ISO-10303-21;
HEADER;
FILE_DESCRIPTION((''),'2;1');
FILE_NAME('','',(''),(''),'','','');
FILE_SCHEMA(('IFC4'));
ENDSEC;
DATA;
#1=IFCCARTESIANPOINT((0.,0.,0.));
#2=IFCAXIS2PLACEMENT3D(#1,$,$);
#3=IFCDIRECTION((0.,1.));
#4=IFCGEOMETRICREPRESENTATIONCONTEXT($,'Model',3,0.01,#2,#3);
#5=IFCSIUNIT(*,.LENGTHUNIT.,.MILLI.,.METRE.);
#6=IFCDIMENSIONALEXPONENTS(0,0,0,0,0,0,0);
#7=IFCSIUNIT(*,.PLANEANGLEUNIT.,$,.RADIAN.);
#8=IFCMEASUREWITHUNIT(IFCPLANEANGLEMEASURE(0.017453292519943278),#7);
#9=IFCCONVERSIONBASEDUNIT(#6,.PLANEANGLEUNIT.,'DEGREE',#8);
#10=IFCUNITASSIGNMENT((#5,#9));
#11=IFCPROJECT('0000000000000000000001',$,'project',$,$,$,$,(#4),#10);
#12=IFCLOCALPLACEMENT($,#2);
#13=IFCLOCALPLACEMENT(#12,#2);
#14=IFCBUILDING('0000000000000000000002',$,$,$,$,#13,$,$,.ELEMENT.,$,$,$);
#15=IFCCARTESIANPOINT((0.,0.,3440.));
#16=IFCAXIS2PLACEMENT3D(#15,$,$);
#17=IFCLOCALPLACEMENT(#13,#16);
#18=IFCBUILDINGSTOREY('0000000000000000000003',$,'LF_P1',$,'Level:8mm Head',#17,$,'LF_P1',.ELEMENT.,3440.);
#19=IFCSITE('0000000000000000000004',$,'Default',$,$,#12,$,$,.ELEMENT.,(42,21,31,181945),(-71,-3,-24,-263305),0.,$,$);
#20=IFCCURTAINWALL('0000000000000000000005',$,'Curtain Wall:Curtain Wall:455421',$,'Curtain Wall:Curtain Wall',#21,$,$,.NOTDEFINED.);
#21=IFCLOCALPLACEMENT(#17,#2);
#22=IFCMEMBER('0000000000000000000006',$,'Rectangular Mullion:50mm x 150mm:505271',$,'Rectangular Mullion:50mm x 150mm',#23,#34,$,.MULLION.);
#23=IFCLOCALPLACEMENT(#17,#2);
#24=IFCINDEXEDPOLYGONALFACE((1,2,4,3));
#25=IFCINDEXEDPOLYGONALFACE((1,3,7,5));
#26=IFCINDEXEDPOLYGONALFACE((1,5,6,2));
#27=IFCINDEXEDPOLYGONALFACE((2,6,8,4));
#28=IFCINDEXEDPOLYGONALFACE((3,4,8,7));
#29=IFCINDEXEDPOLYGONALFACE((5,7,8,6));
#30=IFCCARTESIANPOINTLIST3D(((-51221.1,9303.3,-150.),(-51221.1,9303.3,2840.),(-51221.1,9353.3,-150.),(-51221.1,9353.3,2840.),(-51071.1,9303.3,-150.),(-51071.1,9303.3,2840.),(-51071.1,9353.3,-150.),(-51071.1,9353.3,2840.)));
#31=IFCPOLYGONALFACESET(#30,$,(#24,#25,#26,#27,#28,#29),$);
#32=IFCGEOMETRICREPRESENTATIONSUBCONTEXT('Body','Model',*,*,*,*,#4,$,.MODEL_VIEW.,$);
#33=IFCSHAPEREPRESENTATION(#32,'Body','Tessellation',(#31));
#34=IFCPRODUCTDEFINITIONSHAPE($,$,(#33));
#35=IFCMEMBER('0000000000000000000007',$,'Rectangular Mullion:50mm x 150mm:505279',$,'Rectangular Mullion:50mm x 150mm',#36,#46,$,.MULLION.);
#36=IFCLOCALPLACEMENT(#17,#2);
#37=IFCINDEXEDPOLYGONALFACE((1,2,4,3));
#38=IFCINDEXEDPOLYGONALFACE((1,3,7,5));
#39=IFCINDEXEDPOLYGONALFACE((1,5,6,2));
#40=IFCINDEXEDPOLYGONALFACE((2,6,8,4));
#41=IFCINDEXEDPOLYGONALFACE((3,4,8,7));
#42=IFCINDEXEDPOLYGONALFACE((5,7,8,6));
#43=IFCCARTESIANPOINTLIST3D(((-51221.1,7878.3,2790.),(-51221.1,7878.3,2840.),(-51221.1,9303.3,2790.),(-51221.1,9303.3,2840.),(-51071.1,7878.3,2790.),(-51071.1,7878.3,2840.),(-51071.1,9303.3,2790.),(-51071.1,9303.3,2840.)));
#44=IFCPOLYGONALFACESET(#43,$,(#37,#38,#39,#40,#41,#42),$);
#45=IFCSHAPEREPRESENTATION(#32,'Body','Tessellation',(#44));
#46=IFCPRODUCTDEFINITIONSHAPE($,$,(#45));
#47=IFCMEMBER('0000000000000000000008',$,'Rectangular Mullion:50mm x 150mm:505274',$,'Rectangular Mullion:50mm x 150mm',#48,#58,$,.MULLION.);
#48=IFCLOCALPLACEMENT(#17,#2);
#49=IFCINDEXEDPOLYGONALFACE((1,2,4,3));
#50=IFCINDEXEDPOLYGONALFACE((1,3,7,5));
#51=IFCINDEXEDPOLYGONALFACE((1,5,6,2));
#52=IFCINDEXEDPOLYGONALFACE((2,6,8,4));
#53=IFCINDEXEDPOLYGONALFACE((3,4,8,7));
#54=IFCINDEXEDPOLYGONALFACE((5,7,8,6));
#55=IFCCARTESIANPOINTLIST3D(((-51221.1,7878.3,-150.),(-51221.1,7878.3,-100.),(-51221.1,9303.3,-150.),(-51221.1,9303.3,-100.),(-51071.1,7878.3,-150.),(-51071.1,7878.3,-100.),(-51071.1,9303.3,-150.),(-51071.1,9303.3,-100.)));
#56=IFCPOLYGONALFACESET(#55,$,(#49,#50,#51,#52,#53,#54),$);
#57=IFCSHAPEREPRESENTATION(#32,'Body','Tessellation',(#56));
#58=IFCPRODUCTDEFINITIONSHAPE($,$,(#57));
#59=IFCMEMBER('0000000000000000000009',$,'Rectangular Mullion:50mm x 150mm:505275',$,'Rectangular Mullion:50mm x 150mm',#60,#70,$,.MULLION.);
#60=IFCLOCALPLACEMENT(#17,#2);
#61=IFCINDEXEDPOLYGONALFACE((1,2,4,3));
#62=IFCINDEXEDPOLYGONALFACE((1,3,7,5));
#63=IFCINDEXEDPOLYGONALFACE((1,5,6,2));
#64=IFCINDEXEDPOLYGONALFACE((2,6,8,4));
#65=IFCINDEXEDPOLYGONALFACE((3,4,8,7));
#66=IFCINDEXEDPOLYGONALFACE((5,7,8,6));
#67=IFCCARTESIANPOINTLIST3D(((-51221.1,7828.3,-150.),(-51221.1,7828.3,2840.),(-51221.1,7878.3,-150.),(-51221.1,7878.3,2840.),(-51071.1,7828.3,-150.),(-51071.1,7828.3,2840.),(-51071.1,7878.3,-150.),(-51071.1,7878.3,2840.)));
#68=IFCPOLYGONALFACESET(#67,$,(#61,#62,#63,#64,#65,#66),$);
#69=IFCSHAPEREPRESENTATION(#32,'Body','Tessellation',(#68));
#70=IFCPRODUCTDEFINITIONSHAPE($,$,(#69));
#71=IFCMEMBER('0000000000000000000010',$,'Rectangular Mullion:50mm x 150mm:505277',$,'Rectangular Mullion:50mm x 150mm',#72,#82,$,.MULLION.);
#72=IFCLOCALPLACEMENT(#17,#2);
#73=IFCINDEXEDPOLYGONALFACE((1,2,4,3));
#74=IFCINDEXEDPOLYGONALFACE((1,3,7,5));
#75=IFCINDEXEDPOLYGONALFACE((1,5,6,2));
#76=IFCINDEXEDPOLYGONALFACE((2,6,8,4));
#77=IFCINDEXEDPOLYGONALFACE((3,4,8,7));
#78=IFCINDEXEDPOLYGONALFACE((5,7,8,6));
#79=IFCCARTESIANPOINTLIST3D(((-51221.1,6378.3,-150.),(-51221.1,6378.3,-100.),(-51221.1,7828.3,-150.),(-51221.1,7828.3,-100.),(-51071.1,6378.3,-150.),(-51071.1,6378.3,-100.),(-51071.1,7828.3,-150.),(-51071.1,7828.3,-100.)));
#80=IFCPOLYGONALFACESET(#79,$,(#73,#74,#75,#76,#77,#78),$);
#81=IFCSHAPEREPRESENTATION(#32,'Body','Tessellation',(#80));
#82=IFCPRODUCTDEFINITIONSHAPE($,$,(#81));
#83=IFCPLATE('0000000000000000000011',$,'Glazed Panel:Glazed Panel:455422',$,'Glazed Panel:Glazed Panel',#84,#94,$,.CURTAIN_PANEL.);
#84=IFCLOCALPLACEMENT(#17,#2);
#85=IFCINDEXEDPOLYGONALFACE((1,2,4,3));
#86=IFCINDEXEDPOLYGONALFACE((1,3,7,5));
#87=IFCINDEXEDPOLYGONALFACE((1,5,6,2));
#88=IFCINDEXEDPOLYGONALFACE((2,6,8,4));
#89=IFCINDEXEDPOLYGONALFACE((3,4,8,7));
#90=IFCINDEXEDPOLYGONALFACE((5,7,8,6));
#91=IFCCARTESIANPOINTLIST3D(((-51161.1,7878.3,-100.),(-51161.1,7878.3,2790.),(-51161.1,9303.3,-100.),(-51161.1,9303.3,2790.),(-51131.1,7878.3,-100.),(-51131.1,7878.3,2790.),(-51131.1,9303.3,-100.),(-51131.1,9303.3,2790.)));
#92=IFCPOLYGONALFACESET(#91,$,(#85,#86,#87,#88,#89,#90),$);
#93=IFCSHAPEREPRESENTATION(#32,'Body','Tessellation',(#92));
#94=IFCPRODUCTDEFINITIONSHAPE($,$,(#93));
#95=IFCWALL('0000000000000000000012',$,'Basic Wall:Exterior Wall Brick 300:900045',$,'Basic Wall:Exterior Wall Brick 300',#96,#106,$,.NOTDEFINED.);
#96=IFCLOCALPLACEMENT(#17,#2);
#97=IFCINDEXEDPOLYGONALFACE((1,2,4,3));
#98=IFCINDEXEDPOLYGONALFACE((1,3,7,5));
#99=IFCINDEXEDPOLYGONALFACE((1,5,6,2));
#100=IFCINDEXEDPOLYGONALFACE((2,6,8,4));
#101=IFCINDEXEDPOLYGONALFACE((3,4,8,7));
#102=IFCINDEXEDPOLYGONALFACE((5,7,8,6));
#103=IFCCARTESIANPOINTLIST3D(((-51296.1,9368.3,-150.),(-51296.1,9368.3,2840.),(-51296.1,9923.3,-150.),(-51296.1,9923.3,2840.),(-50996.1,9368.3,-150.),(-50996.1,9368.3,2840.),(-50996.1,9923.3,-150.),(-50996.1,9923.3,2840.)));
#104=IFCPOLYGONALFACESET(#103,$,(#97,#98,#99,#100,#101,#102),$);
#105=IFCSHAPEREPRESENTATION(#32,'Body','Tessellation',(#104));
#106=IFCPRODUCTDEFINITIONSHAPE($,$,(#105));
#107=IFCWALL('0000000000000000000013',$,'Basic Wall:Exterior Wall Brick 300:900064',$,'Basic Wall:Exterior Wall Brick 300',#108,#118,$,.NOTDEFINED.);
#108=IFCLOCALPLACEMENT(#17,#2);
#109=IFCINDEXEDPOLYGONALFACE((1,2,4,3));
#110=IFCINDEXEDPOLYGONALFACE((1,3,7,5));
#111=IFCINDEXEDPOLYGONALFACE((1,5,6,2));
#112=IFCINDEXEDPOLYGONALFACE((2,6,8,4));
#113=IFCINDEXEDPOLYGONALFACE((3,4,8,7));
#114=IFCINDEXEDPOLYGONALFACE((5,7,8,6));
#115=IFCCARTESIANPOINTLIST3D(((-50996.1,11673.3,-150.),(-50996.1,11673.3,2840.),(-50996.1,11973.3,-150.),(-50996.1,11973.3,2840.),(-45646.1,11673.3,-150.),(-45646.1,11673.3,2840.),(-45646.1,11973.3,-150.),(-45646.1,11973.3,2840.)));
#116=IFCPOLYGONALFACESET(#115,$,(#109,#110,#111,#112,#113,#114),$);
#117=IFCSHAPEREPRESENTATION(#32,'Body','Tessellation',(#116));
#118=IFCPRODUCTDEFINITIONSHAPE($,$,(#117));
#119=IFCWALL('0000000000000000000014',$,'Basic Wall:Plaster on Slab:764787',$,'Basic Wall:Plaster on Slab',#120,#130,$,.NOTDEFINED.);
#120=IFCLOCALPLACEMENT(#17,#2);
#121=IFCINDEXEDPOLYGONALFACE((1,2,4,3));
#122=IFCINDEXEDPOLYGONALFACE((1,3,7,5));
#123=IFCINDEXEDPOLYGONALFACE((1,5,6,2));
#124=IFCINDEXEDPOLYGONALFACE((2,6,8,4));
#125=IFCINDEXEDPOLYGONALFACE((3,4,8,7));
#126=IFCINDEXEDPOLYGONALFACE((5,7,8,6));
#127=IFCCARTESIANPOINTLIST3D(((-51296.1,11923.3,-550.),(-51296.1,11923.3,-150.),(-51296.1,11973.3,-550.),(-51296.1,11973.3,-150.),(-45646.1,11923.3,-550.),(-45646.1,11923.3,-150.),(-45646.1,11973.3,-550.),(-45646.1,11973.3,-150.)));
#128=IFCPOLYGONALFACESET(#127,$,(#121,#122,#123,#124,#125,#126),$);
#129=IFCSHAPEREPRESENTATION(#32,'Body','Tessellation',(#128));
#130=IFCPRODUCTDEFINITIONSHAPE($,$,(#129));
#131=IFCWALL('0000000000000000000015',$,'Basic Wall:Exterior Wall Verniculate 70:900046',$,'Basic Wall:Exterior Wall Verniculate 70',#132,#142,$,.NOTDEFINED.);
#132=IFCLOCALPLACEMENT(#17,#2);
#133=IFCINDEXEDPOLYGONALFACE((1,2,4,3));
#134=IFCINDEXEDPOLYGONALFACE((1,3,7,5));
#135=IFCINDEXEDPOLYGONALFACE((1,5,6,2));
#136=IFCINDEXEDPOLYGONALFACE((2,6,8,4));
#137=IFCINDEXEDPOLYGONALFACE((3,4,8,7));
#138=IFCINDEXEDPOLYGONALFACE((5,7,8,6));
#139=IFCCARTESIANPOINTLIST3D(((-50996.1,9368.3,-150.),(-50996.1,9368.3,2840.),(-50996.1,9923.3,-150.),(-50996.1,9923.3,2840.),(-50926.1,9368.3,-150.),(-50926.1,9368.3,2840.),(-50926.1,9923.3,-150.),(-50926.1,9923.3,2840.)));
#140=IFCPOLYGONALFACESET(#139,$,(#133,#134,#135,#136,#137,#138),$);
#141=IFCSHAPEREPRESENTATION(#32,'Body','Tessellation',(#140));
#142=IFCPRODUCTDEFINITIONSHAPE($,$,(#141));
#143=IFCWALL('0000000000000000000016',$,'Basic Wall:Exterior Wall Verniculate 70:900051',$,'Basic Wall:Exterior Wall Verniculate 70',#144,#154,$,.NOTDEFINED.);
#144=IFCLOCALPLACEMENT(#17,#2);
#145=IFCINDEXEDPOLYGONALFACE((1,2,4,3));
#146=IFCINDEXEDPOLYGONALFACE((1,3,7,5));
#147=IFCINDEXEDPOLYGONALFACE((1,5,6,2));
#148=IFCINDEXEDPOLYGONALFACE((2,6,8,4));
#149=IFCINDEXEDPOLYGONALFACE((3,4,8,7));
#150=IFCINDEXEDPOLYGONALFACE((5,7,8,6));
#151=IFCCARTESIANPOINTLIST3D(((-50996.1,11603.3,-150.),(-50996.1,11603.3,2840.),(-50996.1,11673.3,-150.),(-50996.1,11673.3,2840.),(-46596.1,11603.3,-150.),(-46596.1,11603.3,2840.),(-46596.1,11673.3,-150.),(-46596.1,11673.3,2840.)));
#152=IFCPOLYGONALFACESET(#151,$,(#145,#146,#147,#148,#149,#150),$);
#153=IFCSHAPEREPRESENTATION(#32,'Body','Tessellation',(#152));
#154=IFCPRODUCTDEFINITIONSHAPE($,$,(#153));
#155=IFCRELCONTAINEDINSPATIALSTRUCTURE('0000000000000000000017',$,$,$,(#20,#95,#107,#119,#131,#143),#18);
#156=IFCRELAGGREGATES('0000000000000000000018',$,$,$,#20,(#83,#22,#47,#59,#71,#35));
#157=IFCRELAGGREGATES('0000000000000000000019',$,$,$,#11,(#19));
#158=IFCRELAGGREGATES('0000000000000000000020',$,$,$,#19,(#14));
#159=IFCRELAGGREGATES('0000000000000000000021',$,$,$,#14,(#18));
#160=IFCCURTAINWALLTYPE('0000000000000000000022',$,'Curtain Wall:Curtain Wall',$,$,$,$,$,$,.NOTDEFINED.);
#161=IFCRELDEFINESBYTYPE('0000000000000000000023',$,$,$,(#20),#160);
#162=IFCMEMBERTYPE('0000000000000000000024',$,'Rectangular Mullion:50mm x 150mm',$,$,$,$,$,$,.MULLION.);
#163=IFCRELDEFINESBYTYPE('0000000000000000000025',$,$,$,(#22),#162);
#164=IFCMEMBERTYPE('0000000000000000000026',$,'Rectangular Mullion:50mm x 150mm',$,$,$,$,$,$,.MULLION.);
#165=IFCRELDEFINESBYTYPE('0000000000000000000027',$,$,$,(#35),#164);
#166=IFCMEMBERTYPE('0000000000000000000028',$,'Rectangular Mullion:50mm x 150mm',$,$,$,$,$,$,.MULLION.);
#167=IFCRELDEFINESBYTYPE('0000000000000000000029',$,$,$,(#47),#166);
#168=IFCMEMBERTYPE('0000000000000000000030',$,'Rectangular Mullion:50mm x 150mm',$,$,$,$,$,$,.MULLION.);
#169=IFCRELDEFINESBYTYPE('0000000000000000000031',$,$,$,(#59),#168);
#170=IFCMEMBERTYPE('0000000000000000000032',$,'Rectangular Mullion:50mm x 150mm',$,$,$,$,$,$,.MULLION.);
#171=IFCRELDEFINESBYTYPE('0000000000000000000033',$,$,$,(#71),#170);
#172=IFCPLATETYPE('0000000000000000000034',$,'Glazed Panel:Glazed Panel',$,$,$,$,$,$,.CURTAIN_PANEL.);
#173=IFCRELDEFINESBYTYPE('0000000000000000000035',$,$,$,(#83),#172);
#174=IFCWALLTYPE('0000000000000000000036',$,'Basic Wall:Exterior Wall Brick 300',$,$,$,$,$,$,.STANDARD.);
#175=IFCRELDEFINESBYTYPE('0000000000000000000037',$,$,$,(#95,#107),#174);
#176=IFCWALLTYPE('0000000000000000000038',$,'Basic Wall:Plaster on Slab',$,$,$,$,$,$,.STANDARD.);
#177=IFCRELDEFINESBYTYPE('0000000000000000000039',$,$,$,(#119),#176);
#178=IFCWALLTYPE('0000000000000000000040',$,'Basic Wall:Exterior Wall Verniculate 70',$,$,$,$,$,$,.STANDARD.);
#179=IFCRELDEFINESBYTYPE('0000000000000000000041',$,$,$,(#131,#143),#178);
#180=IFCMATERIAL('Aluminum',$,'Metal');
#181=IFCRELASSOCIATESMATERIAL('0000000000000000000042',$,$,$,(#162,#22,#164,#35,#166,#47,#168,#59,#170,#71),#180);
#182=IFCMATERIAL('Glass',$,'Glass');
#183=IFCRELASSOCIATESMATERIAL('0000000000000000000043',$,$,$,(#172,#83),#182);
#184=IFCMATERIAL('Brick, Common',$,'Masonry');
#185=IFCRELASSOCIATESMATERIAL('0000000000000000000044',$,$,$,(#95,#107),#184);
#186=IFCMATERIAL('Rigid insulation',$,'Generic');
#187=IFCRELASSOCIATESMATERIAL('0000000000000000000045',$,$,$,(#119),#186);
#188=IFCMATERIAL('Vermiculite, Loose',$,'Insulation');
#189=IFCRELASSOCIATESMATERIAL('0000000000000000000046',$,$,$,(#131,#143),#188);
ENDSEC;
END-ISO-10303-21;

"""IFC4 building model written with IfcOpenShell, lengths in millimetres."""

from ifc_helpers import new_model, entity, si_unit, converted_unit, direction, frame, origin, place, context, subcontext, project, spatial, indexed_curve, outline, extrude, source, transform, mapped, material, type_object, type_shapes, element, aggregate, save


model = new_model("IFC4")

# Units and contexts
model_context = context("Model", 3, precision=0.01, world=origin(), true_north=direction((0.0, 1.0)))
body_context = subcontext(model_context, "Body", "Model", "MODEL_VIEW")
ifc_project = project(units=[si_unit("LENGTHUNIT", "METRE", prefix="MILLI"), converted_unit("PLANEANGLEUNIT", "DEGREE", entity("IfcPlaneAngleMeasure", 0.017453292519943278), si_unit("PLANEANGLEUNIT", "RADIAN"), dimensions=[0, 0, 0, 0, 0, 0, 0])], contexts=[model_context])

# Site, building, storey
site_placement = place(None, origin())
site = spatial("IfcSite", under=ifc_project, at=site_placement, Name="Default", CompositionType="ELEMENT", RefLatitude=(42, 21, 31, 181945), RefLongitude=(-71, -3, -24, -263305), RefElevation=0.0)
building_placement = place(site_placement, origin())
building = spatial("IfcBuilding", under=site, at=building_placement, CompositionType="ELEMENT")
storey_placement = place(building_placement, frame((0.0, 0.0, 3440.0)))
storey = spatial("IfcBuildingStorey", under=building, at=storey_placement, Name="LF_P1", ObjectType="Level:8mm Head", LongName="LF_P1", CompositionType="ELEMENT", Elevation=3440.0)

# Curtain wall, members, plate
curtain_wall_type = type_object("IfcCurtainWallType", Name="Curtain Wall:Curtain Wall", PredefinedType="NOTDEFINED")
curtain_wall_placement = place(storey_placement, frame((0.0, 0.0, -3440.0)))
curtain_wall = element("IfcCurtainWall", 1, at=curtain_wall_placement, inside=storey, type_object=curtain_wall_type, Name="Curtain Wall:Curtain Wall:455421", ObjectType="Curtain Wall:Curtain Wall", PredefinedType="NOTDEFINED")
ifc_material_1 = material(Name="Aluminum", Category="Metal")
member_type_1 = type_object("IfcMemberType", Name="Rectangular Mullion:50mm x 150mm", PredefinedType="MULLION", material=ifc_material_1)
shared_shape_1 = source(origin(), body_context, "Body", "SweptSolid", [
    extrude(outline(indexed_curve([(-25.0, -75.0), (25.0, -75.0), (25.0, 75.0), (-25.0, 75.0), (-25.0, -75.0)], self_intersect=False)), frame((-25.0, 0.0, -2990.0), z_axis=(0.0, 0.0, 1.0), x_axis=(-1.0, 0.0, 0.0)), (0.0, 0.0, 1.0), 2990.0),
])
type_shapes(member_type_1, [shared_shape_1])
member_1_placement = place(curtain_wall_placement, frame((-51146.1, 9353.3, 6280.0), z_axis=(0.0, 0.0, 1.0), x_axis=(0.0, 1.0, 0.0)))
member_1 = element("IfcMember", 2, at=member_1_placement, type_object=member_type_1, material=ifc_material_1, Name="Rectangular Mullion:50mm x 150mm:505271", ObjectType="Rectangular Mullion:50mm x 150mm", PredefinedType="MULLION", context=body_context, shape_type="MappedRepresentation", body=[
    mapped(shared_shape_1, transform((0.0, 0.0, 0.0), scale=1.0)),
])
member_type_2 = type_object("IfcMemberType", Name="Rectangular Mullion:50mm x 150mm", PredefinedType="MULLION", material=ifc_material_1)
shared_shape_2 = source(origin(), body_context, "Body", "SweptSolid", [
    extrude(outline(indexed_curve([(-25.0, -75.0), (25.0, -75.0), (25.0, 75.0), (-25.0, 75.0), (-25.0, -75.0)], self_intersect=False)), frame((-25.0, 0.0, -1425.0), z_axis=(0.0, 0.0, 1.0), x_axis=(-1.0, 0.0, 0.0)), (0.0, 0.0, 1.0), 1425.0),
])
type_shapes(member_type_2, [shared_shape_2])
member_2_placement = place(curtain_wall_placement, frame((-51146.1, 7878.3, 6280.0), z_axis=(0.0, -1.0, 0.0), x_axis=(0.0, 0.0, 1.0)))
member_2 = element("IfcMember", 3, at=member_2_placement, type_object=member_type_2, material=ifc_material_1, Name="Rectangular Mullion:50mm x 150mm:505279", ObjectType="Rectangular Mullion:50mm x 150mm", PredefinedType="MULLION", context=body_context, shape_type="MappedRepresentation", body=[
    mapped(shared_shape_2, transform((0.0, 0.0, 0.0), scale=1.0)),
])
member_type_3 = type_object("IfcMemberType", Name="Rectangular Mullion:50mm x 150mm", PredefinedType="MULLION", material=ifc_material_1)
shared_shape_3 = source(origin(), body_context, "Body", "SweptSolid", [
    extrude(outline(indexed_curve([(-25.0, -75.0), (25.0, -75.0), (25.0, 75.0), (-25.0, 75.0), (-25.0, -75.0)], self_intersect=False)), frame((-25.0, 0.0, -1425.0), z_axis=(0.0, 0.0, 1.0), x_axis=(-1.0, 0.0, 0.0)), (0.0, 0.0, 1.0), 1425.0),
])
type_shapes(member_type_3, [shared_shape_3])
member_3_placement = place(curtain_wall_placement, frame((-51146.1, 9303.3, 3290.0), z_axis=(0.0, 1.0, 0.0), x_axis=(0.0, 0.0, -1.0)))
member_3 = element("IfcMember", 4, at=member_3_placement, type_object=member_type_3, material=ifc_material_1, Name="Rectangular Mullion:50mm x 150mm:505274", ObjectType="Rectangular Mullion:50mm x 150mm", PredefinedType="MULLION", context=body_context, shape_type="MappedRepresentation", body=[
    mapped(shared_shape_3, transform((0.0, 0.0, 0.0), scale=1.0)),
])
member_type_4 = type_object("IfcMemberType", Name="Rectangular Mullion:50mm x 150mm", PredefinedType="MULLION", material=ifc_material_1)
shared_shape_4 = source(origin(), body_context, "Body", "SweptSolid", [
    extrude(outline(indexed_curve([(-25.0, -75.0), (25.0, -75.0), (25.0, 75.0), (-25.0, 75.0), (-25.0, -75.0)], self_intersect=False)), frame((0.0, 0.0, -2990.0), z_axis=(0.0, 0.0, 1.0), x_axis=(-1.0, 0.0, 0.0)), (0.0, 0.0, 1.0), 2990.0),
])
type_shapes(member_type_4, [shared_shape_4])
member_4_placement = place(curtain_wall_placement, frame((-51146.1, 7853.3, 3290.0), z_axis=(0.0, 0.0, -1.0), x_axis=(0.0, -1.0, 0.0)))
member_4 = element("IfcMember", 5, at=member_4_placement, type_object=member_type_4, material=ifc_material_1, Name="Rectangular Mullion:50mm x 150mm:505275", ObjectType="Rectangular Mullion:50mm x 150mm", PredefinedType="MULLION", context=body_context, shape_type="MappedRepresentation", body=[
    mapped(shared_shape_4, transform((0.0, 0.0, 0.0), scale=1.0)),
])
member_type_5 = type_object("IfcMemberType", Name="Rectangular Mullion:50mm x 150mm", PredefinedType="MULLION", material=ifc_material_1)
shared_shape_5 = source(origin(), body_context, "Body", "SweptSolid", [
    extrude(outline(indexed_curve([(-25.0, -75.0), (25.0, -75.0), (25.0, 75.0), (-25.0, 75.0), (-25.0, -75.0)], self_intersect=False)), frame((-25.0, 0.0, -1450.0), z_axis=(0.0, 0.0, 1.0), x_axis=(-1.0, 0.0, 0.0)), (0.0, 0.0, 1.0), 1450.0),
])
type_shapes(member_type_5, [shared_shape_5])
member_5_placement = place(curtain_wall_placement, frame((-51146.1, 7828.3, 3290.0), z_axis=(0.0, 1.0, 0.0), x_axis=(0.0, 0.0, -1.0)))
member_5 = element("IfcMember", 6, at=member_5_placement, type_object=member_type_5, material=ifc_material_1, Name="Rectangular Mullion:50mm x 150mm:505277", ObjectType="Rectangular Mullion:50mm x 150mm", PredefinedType="MULLION", context=body_context, shape_type="MappedRepresentation", body=[
    mapped(shared_shape_5, transform((0.0, 0.0, 0.0), scale=1.0)),
])
ifc_material_2 = material(Name="Glass", Category="Glass")
plate_type = type_object("IfcPlateType", Name="Glazed Panel:Glazed Panel", PredefinedType="CURTAIN_PANEL", material=ifc_material_2)
shared_shape_6 = source(origin(), body_context, "Body", "SweptSolid", [
    extrude(outline(indexed_curve([(-15.0, -712.5), (15.0, -712.5), (15.0, 712.5), (-15.0, 712.5), (-15.0, -712.5)], self_intersect=False)), frame((0.0, 0.0, 0.0), z_axis=(0.0, 0.0, 1.0), x_axis=(0.0, 1.0, 0.0)), (0.0, 0.0, 1.0), 2890.0),
])
type_shapes(plate_type, [shared_shape_6])
plate_placement = place(curtain_wall_placement, frame((-51146.1, 8590.8, 3340.0), z_axis=(0.0, 0.0, 1.0), x_axis=(0.0, -1.0, 0.0)))
plate = element("IfcPlate", 7, at=plate_placement, type_object=plate_type, material=ifc_material_2, Name="Glazed Panel:Glazed Panel:455422", ObjectType="Glazed Panel:Glazed Panel", PredefinedType="CURTAIN_PANEL", context=body_context, shape_type="MappedRepresentation", body=[
    mapped(shared_shape_6, transform((0.0, 0.0, 0.0), scale=1.0)),
])
aggregate(curtain_wall, [plate, member_1, member_3, member_4, member_5, member_2])

# Walls
ifc_material_3 = material(Name="Brick, Common", Category="Masonry")
wall_type_1 = type_object("IfcWallType", Name="Basic Wall:Exterior Wall Brick 300", PredefinedType="STANDARD")
wall_1_placement = place(storey_placement, frame((-51146.1, 9923.3, -150.0), z_axis=(0.0, 0.0, 1.0), x_axis=(0.0, -1.0, 0.0)))
element("IfcWall", 8, at=wall_1_placement, inside=storey, type_object=wall_type_1, material=ifc_material_3, Name="Basic Wall:Exterior Wall Brick 300:900045", ObjectType="Basic Wall:Exterior Wall Brick 300", PredefinedType="NOTDEFINED", context=body_context, shape_type="SweptSolid", body=[
    extrude(outline(indexed_curve([(555.0, 150.0), (0.0, 150.0), (0.0, -150.0), (555.0, -150.0), (555.0, 150.0)], self_intersect=False)), origin(), (0.0, 0.0, 1.0), 2990.0),
])
wall_2_placement = place(storey_placement, frame((-45646.1, 11823.3, -150.0), z_axis=(0.0, 0.0, 1.0), x_axis=(-1.0, 0.0, 0.0)))
element("IfcWall", 9, at=wall_2_placement, inside=storey, type_object=wall_type_1, material=ifc_material_3, Name="Basic Wall:Exterior Wall Brick 300:900064", ObjectType="Basic Wall:Exterior Wall Brick 300", PredefinedType="NOTDEFINED", context=body_context, shape_type="SweptSolid", body=[
    extrude(outline(indexed_curve([(5350.0, 150.0), (0.0, 150.0), (0.0, -150.0), (5350.0, -150.0), (5350.0, 150.0)], self_intersect=False)), origin(), (0.0, 0.0, 1.0), 2990.0),
])
ifc_material_4 = material(Name="Rigid insulation", Category="Generic")
wall_type_2 = type_object("IfcWallType", Name="Basic Wall:Plaster on Slab", PredefinedType="STANDARD")
wall_3_placement = place(storey_placement, frame((-45646.1, 11948.3, -550.0), z_axis=(0.0, 0.0, 1.0), x_axis=(-1.0, 0.0, 0.0)))
element("IfcWall", 10, at=wall_3_placement, inside=storey, type_object=wall_type_2, material=ifc_material_4, Name="Basic Wall:Plaster on Slab:764787", ObjectType="Basic Wall:Plaster on Slab", PredefinedType="NOTDEFINED", context=body_context, shape_type="SweptSolid", body=[
    extrude(outline(indexed_curve([(5650.0, 25.0), (0.0, 25.0), (0.0, -25.0), (5650.0, -25.0), (5650.0, 25.0)], self_intersect=False)), origin(), (0.0, 0.0, 1.0), 400.0),
])
ifc_material_5 = material(Name="Vermiculite, Loose", Category="Insulation")
wall_type_3 = type_object("IfcWallType", Name="Basic Wall:Exterior Wall Verniculate 70", PredefinedType="STANDARD")
wall_4_placement = place(storey_placement, frame((-50961.1, 9923.3, -150.0), z_axis=(0.0, 0.0, 1.0), x_axis=(0.0, -1.0, 0.0)))
element("IfcWall", 11, at=wall_4_placement, inside=storey, type_object=wall_type_3, material=ifc_material_5, Name="Basic Wall:Exterior Wall Verniculate 70:900046", ObjectType="Basic Wall:Exterior Wall Verniculate 70", PredefinedType="NOTDEFINED", context=body_context, shape_type="SweptSolid", body=[
    extrude(outline(indexed_curve([(555.0, 35.0), (0.0, 35.0), (0.0, -35.0), (555.0, -35.0), (555.0, 35.0)], self_intersect=False)), origin(), (0.0, 0.0, 1.0), 2990.0),
])
wall_5_placement = place(storey_placement, frame((-50996.1, 11638.3, -150.0)))
element("IfcWall", 12, at=wall_5_placement, inside=storey, type_object=wall_type_3, material=ifc_material_5, Name="Basic Wall:Exterior Wall Verniculate 70:900051", ObjectType="Basic Wall:Exterior Wall Verniculate 70", PredefinedType="NOTDEFINED", context=body_context, shape_type="SweptSolid", body=[
    extrude(outline(indexed_curve([(4400.0, 35.0), (0.0, 35.0), (0.0, -35.0), (4400.0, -35.0), (4400.0, 35.0)], self_intersect=False)), origin(), (0.0, 0.0, 1.0), 2990.0),
])

save(model, "model.ifc")
